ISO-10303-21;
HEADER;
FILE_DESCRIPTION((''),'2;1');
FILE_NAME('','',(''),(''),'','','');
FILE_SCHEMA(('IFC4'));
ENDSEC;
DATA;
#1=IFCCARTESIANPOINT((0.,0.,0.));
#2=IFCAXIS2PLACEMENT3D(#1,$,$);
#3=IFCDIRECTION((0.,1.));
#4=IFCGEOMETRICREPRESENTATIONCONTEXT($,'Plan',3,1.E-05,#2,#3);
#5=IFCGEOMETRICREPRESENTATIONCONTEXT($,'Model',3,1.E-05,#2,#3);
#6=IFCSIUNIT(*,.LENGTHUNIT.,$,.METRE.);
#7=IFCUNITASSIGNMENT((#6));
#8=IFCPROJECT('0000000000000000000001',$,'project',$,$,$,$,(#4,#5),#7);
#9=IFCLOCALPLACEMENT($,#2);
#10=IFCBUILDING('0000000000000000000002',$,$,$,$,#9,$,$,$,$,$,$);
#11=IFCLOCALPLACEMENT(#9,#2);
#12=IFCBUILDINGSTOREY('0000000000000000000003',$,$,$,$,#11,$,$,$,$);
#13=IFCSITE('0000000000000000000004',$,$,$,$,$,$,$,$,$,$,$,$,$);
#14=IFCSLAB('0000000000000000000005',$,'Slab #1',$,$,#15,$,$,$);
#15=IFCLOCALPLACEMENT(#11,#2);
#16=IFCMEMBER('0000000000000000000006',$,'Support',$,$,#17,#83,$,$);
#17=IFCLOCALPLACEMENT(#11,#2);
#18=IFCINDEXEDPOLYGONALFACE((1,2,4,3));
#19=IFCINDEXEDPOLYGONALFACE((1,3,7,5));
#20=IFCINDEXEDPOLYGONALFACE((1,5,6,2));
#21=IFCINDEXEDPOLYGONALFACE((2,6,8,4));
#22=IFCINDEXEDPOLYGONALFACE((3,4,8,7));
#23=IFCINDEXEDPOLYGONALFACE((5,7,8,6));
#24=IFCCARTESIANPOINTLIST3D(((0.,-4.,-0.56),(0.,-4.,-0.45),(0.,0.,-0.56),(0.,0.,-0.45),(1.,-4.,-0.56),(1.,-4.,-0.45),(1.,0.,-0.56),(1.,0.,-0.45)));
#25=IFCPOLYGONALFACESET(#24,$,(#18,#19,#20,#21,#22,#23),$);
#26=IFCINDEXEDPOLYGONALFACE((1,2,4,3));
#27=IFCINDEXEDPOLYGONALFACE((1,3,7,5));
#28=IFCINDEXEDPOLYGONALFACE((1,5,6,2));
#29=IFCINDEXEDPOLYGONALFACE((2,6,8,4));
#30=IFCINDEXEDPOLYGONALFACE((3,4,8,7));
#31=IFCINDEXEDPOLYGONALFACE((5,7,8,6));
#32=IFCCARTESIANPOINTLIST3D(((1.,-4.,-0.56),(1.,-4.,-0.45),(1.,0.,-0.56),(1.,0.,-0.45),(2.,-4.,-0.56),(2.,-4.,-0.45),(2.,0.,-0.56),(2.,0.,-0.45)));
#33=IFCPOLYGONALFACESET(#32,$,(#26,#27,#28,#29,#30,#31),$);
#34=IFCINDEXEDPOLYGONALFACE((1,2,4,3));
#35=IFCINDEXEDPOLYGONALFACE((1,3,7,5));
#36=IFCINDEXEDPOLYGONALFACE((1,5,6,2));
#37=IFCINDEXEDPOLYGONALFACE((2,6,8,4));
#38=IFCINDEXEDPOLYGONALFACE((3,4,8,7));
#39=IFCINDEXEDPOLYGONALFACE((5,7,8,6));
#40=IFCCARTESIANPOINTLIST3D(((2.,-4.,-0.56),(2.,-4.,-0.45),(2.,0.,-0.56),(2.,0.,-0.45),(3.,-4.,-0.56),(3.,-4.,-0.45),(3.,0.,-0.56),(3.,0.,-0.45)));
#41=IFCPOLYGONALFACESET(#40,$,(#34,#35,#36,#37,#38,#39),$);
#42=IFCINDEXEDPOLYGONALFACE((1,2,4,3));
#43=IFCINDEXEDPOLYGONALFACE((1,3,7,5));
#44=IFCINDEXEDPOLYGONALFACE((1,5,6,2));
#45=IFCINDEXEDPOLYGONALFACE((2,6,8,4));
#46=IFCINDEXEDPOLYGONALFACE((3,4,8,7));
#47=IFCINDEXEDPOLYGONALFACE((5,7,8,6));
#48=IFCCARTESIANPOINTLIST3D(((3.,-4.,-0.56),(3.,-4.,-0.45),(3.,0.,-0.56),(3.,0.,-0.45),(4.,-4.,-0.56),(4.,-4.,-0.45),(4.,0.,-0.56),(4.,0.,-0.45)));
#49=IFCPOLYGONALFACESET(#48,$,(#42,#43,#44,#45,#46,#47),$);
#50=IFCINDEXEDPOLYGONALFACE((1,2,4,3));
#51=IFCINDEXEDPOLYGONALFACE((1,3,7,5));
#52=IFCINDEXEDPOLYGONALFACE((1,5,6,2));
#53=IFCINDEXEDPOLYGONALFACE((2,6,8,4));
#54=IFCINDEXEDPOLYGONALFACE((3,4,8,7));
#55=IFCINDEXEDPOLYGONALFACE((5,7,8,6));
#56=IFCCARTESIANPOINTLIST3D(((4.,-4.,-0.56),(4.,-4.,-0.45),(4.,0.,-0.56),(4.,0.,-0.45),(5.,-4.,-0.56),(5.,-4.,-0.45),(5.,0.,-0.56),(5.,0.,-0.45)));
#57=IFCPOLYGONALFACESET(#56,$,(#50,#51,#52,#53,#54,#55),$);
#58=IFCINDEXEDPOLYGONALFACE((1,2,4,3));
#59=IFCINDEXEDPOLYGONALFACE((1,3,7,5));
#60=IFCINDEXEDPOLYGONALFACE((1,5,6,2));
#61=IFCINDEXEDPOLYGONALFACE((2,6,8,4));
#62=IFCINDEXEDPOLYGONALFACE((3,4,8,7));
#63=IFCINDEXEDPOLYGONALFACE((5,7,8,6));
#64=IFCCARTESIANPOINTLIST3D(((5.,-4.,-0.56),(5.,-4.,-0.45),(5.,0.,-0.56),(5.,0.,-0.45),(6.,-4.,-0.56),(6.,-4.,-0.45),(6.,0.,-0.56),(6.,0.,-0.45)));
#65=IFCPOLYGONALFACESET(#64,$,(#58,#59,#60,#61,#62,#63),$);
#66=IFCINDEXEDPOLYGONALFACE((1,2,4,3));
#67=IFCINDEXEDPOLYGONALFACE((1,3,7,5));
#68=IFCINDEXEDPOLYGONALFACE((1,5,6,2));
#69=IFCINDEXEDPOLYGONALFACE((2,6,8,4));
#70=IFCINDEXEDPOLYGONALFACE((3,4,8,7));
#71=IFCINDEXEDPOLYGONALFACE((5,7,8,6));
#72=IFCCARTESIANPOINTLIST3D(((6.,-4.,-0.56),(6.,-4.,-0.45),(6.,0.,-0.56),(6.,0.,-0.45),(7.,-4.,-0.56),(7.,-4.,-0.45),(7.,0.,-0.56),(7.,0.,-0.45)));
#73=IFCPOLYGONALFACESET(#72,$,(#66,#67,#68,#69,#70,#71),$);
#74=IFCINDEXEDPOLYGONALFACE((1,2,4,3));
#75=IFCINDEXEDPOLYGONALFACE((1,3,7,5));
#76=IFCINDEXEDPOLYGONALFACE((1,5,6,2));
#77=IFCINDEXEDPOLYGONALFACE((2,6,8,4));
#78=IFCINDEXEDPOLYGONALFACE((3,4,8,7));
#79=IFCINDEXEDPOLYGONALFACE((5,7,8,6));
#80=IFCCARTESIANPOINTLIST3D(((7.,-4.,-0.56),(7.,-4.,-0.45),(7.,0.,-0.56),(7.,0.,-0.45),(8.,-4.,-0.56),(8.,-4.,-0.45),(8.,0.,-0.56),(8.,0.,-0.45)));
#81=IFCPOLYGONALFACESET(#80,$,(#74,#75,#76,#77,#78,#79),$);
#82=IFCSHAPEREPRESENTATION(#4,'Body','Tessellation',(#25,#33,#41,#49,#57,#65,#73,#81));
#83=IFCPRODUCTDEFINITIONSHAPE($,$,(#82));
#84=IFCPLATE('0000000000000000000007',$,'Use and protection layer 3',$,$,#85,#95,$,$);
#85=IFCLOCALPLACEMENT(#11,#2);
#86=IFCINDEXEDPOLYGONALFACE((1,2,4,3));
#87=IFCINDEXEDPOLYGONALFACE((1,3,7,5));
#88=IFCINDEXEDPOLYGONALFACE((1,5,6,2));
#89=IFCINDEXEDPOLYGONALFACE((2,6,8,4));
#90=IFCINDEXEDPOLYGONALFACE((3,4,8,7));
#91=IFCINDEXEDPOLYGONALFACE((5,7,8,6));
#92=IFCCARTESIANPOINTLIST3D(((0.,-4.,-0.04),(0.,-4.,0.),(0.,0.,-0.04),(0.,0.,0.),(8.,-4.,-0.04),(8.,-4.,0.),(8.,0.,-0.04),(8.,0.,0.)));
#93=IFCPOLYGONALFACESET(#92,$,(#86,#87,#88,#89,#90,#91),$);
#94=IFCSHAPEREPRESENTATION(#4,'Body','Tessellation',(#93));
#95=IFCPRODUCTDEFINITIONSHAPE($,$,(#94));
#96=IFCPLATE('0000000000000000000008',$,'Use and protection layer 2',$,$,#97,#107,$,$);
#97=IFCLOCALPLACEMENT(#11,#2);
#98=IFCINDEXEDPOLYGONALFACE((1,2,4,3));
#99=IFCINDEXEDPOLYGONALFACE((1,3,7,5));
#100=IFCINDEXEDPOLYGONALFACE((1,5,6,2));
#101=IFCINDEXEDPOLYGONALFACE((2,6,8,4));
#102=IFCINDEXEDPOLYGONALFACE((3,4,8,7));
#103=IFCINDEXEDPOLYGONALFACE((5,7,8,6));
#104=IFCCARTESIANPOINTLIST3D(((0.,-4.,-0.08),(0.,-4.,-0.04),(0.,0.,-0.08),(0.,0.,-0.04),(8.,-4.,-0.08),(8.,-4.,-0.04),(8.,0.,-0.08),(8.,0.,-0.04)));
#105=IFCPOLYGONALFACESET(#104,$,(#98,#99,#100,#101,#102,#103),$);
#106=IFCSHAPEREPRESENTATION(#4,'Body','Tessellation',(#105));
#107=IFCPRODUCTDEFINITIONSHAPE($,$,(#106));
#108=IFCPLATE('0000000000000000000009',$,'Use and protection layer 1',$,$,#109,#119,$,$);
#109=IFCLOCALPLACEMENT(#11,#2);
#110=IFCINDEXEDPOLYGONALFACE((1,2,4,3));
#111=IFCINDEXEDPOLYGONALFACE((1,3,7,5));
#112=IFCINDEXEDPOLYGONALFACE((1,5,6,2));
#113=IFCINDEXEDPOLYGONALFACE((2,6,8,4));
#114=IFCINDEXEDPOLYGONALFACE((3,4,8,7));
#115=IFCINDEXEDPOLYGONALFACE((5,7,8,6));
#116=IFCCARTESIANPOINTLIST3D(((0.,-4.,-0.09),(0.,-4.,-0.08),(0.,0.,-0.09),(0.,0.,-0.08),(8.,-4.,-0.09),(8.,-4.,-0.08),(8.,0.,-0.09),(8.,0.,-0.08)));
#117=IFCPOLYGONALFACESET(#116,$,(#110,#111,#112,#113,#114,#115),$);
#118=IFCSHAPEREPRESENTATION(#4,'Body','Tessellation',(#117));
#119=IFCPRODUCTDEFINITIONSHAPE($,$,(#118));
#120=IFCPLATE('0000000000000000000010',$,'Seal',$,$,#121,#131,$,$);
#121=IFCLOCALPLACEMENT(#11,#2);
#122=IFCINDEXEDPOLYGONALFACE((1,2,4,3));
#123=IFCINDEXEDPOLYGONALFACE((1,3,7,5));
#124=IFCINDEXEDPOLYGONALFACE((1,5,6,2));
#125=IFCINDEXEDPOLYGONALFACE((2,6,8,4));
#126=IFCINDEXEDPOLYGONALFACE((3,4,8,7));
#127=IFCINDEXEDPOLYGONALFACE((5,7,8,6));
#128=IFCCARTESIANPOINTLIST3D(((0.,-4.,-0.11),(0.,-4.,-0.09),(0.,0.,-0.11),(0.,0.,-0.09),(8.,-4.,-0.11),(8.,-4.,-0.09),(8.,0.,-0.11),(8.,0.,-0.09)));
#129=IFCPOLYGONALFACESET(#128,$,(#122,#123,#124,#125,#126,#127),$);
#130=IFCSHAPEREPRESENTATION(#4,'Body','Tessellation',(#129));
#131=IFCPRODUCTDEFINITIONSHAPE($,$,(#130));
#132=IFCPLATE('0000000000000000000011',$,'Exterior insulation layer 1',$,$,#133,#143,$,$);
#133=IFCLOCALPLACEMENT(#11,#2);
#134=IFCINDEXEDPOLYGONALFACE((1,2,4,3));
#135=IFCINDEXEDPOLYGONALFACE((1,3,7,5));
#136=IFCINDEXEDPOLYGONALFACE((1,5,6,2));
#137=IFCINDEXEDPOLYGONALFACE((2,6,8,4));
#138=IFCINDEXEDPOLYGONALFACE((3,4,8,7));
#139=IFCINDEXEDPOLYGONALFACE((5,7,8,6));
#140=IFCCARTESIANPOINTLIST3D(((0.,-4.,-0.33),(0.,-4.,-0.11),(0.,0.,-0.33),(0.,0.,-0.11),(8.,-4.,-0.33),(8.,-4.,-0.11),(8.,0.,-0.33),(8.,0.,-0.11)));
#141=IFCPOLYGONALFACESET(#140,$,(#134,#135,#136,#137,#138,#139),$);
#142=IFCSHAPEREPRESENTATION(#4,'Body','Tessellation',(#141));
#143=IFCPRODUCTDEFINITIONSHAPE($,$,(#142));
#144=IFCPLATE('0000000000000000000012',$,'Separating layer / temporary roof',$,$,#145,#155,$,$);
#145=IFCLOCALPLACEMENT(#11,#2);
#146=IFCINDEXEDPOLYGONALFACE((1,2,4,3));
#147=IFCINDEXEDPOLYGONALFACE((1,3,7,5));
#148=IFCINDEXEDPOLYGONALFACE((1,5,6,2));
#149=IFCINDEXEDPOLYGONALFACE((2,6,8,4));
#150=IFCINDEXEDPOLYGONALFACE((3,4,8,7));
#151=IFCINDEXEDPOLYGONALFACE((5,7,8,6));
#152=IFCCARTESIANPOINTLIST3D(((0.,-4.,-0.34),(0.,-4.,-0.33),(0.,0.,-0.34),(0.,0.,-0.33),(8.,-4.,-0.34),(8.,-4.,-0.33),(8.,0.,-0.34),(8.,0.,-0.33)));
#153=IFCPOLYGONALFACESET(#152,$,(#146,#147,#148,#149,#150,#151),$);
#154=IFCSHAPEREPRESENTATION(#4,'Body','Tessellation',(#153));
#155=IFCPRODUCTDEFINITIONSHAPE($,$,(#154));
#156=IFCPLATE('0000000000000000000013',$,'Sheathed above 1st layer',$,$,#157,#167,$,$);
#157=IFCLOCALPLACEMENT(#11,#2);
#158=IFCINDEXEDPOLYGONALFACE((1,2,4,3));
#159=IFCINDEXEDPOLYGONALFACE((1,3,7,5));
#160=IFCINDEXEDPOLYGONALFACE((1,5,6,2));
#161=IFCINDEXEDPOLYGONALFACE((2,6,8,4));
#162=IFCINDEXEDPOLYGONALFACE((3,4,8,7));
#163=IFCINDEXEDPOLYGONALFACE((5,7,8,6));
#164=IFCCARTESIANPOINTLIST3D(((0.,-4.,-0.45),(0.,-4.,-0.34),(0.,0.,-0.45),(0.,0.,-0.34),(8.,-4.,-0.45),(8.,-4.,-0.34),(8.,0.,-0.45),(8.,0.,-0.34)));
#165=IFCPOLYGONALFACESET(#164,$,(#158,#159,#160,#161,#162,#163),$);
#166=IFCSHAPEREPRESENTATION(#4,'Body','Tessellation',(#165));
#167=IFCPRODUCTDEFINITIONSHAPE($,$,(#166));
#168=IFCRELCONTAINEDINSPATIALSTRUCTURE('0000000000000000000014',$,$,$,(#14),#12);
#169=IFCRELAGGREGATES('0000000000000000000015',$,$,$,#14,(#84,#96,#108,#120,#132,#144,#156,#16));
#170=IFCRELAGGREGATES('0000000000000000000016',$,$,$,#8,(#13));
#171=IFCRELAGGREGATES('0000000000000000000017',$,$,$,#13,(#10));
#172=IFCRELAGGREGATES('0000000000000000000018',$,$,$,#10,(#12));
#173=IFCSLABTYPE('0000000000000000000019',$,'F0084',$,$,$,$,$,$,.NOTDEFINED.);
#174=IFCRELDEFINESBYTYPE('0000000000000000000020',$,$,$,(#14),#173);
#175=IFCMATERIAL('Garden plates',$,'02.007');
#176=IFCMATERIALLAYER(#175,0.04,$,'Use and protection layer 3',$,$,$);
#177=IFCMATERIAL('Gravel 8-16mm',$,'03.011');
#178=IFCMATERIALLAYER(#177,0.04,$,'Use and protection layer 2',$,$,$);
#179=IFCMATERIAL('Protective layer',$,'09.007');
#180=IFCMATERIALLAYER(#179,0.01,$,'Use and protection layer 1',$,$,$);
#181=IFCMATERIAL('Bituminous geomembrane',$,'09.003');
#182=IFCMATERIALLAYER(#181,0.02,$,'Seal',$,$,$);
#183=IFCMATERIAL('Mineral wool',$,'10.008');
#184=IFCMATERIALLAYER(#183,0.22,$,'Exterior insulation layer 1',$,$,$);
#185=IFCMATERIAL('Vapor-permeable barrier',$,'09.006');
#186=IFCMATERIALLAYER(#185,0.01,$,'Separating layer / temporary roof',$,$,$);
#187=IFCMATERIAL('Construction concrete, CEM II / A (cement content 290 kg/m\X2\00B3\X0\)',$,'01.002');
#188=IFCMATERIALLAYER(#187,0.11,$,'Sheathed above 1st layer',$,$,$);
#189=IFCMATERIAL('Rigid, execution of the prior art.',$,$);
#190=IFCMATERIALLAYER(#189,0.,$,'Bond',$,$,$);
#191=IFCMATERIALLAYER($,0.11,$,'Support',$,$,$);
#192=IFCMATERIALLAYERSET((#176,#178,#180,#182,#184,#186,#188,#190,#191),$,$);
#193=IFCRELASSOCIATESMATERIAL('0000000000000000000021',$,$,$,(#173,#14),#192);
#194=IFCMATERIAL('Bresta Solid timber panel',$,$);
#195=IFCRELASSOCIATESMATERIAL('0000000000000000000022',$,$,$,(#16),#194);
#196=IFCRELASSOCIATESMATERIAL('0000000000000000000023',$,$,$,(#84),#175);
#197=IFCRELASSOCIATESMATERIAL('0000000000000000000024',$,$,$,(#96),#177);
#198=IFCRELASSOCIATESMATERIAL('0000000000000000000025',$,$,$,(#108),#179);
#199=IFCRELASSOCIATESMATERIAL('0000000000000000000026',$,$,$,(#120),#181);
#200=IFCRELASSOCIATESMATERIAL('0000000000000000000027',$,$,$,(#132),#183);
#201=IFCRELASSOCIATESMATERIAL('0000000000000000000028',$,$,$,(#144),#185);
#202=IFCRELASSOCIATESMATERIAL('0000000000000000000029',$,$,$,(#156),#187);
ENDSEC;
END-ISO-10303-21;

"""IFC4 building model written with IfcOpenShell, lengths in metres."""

from ifc_helpers import new_model, si_unit, direction, frame, frame_2d, origin, origin_with_axes, place, context, project, spatial, rectangle, extrude, material, layer, layer_set, type_object, element, aggregate, save


model = new_model("IFC4")

# Units and contexts
plan_context = context("Plan", 3, precision=1e-05, world=origin(), true_north=direction((0.0, 1.0)))
model_context = context("Model", 3, precision=1e-05, world=origin(), true_north=direction((0.0, 1.0)))
ifc_project = project(units=[si_unit("LENGTHUNIT", "METRE")], contexts=[plan_context, model_context])

# Site, building, storey
site = spatial("IfcSite", under=ifc_project)
building_placement = place(None, origin())
building = spatial("IfcBuilding", under=site, at=building_placement)
storey_placement = place(building_placement, origin())
storey = spatial("IfcBuildingStorey", under=building, at=storey_placement)

# Slab, member, plates
ifc_material_1 = material(Name="Garden plates", Category="02.007")
ifc_layer_1 = layer(ifc_material_1, 0.04, Name="Use and protection layer 3")
ifc_material_2 = material(Name="Gravel 8-16mm", Category="03.011")
ifc_layer_2 = layer(ifc_material_2, 0.04, Name="Use and protection layer 2")
ifc_material_3 = material(Name="Protective layer", Category="09.007")
ifc_layer_3 = layer(ifc_material_3, 0.01, Name="Use and protection layer 1")
ifc_material_4 = material(Name="Bituminous geomembrane", Category="09.003")
ifc_layer_4 = layer(ifc_material_4, 0.02, Name="Seal")
ifc_material_5 = material(Name="Mineral wool", Category="10.008")
ifc_layer_5 = layer(ifc_material_5, 0.22, Name="Exterior insulation layer 1")
ifc_material_6 = material(Name="Vapor-permeable barrier", Category="09.006")
ifc_layer_6 = layer(ifc_material_6, 0.01, Name="Separating layer / temporary roof")
ifc_material_7 = material(Name="Construction concrete, CEM II / A (cement content 290 kg/m³)", Category="01.002")
ifc_layer_7 = layer(ifc_material_7, 0.11, Name="Sheathed above 1st layer")
ifc_material_8 = material(Name="Rigid, execution of the prior art.")
ifc_layer_8 = layer(ifc_material_8, 0.0, Name="Bond")
ifc_layer_9 = layer(None, 0.11, Name="Support")
ifc_layer_set = layer_set([ifc_layer_1, ifc_layer_2, ifc_layer_3, ifc_layer_4, ifc_layer_5, ifc_layer_6, ifc_layer_7, ifc_layer_8, ifc_layer_9])
slab_type = type_object("IfcSlabType", Name="F0084", PredefinedType="NOTDEFINED", material=ifc_layer_set)
slab_placement = place(None, frame((0.0, 0.0, 0.0), z_axis=(0.0, 0.0, -1.0), x_axis=(1.0, 0.0, 0.0)))
slab = element("IfcSlab", 1, at=slab_placement, inside=storey, type_object=slab_type, material=ifc_layer_set, Name="Slab #1")
ifc_material_9 = material(Name="Bresta Solid timber panel")
member_placement = place(slab_placement, origin())
member = element("IfcMember", 2, at=member_placement, material=ifc_material_9, Name="Support", context=plan_context, shape_type="SweptSolid", body=[
    extrude(rectangle(XDim=1.0, YDim=0.11, at=frame_2d((0.5, 0.055), x_axis=(1.0, 0.0))), frame((0.0, 4.0, 0.45), z_axis=(0.0, -1.0, 0.0), x_axis=(1.0, 0.0, 0.0)), (0.0, 0.0, 1.0), 4.0),
    extrude(rectangle(XDim=1.0, YDim=0.11, at=frame_2d((0.5, 0.055), x_axis=(1.0, 0.0))), frame((1.0, 4.0, 0.45), z_axis=(0.0, -1.0, 0.0), x_axis=(1.0, 0.0, 0.0)), (0.0, 0.0, 1.0), 4.0),
    extrude(rectangle(XDim=1.0, YDim=0.11, at=frame_2d((0.5, 0.055), x_axis=(1.0, 0.0))), frame((2.0, 4.0, 0.45), z_axis=(0.0, -1.0, 0.0), x_axis=(1.0, 0.0, 0.0)), (0.0, 0.0, 1.0), 4.0),
    extrude(rectangle(XDim=1.0, YDim=0.11, at=frame_2d((0.5, 0.055), x_axis=(1.0, 0.0))), frame((3.0, 4.0, 0.45), z_axis=(0.0, -1.0, 0.0), x_axis=(1.0, 0.0, 0.0)), (0.0, 0.0, 1.0), 4.0),
    extrude(rectangle(XDim=1.0, YDim=0.11, at=frame_2d((0.5, 0.055), x_axis=(1.0, 0.0))), frame((4.0, 4.0, 0.45), z_axis=(0.0, -1.0, 0.0), x_axis=(1.0, 0.0, 0.0)), (0.0, 0.0, 1.0), 4.0),
    extrude(rectangle(XDim=1.0, YDim=0.11, at=frame_2d((0.5, 0.055), x_axis=(1.0, 0.0))), frame((5.0, 4.0, 0.45), z_axis=(0.0, -1.0, 0.0), x_axis=(1.0, 0.0, 0.0)), (0.0, 0.0, 1.0), 4.0),
    extrude(rectangle(XDim=1.0, YDim=0.11, at=frame_2d((0.5, 0.055), x_axis=(1.0, 0.0))), frame((6.0, 4.0, 0.45), z_axis=(0.0, -1.0, 0.0), x_axis=(1.0, 0.0, 0.0)), (0.0, 0.0, 1.0), 4.0),
    extrude(rectangle(XDim=1.0, YDim=0.11, at=frame_2d((0.5, 0.055), x_axis=(1.0, 0.0))), frame((7.0, 4.0, 0.45), z_axis=(0.0, -1.0, 0.0), x_axis=(1.0, 0.0, 0.0)), (0.0, 0.0, 1.0), 4.0),
])
plate_1_placement = place(slab_placement, origin())
plate_1 = element("IfcPlate", 3, at=plate_1_placement, material=ifc_material_1, Name="Use and protection layer 3", context=plan_context, shape_type="SweptSolid", body=[
    extrude(rectangle(XDim=8.0, YDim=4.0, at=frame_2d((4.0, 2.0), x_axis=(1.0, 0.0))), origin_with_axes(), (0.0, 0.0, 1.0), 0.04),
])
plate_2_placement = place(slab_placement, origin())
plate_2 = element("IfcPlate", 4, at=plate_2_placement, material=ifc_material_2, Name="Use and protection layer 2", context=plan_context, shape_type="SweptSolid", body=[
    extrude(rectangle(XDim=8.0, YDim=4.0, at=frame_2d((4.0, 2.0), x_axis=(1.0, 0.0))), frame((0.0, 0.0, 0.04), z_axis=(0.0, 0.0, 1.0), x_axis=(1.0, 0.0, 0.0)), (0.0, 0.0, 1.0), 0.04),
])
plate_3_placement = place(slab_placement, origin())
plate_3 = element("IfcPlate", 5, at=plate_3_placement, material=ifc_material_3, Name="Use and protection layer 1", context=plan_context, shape_type="SweptSolid", body=[
    extrude(rectangle(XDim=8.0, YDim=4.0, at=frame_2d((4.0, 2.0), x_axis=(1.0, 0.0))), frame((0.0, 0.0, 0.08), z_axis=(0.0, 0.0, 1.0), x_axis=(1.0, 0.0, 0.0)), (0.0, 0.0, 1.0), 0.01),
])
plate_4_placement = place(slab_placement, origin())
plate_4 = element("IfcPlate", 6, at=plate_4_placement, material=ifc_material_4, Name="Seal", context=plan_context, shape_type="SweptSolid", body=[
    extrude(rectangle(XDim=8.0, YDim=4.0, at=frame_2d((4.0, 2.0), x_axis=(1.0, 0.0))), frame((0.0, 0.0, 0.09), z_axis=(0.0, 0.0, 1.0), x_axis=(1.0, 0.0, 0.0)), (0.0, 0.0, 1.0), 0.02),
])
plate_5_placement = place(slab_placement, origin())
plate_5 = element("IfcPlate", 7, at=plate_5_placement, material=ifc_material_5, Name="Exterior insulation layer 1", context=plan_context, shape_type="SweptSolid", body=[
    extrude(rectangle(XDim=8.0, YDim=4.0, at=frame_2d((4.0, 2.0), x_axis=(1.0, 0.0))), frame((0.0, 0.0, 0.11), z_axis=(0.0, 0.0, 1.0), x_axis=(1.0, 0.0, 0.0)), (0.0, 0.0, 1.0), 0.22),
])
plate_6_placement = place(slab_placement, origin())
plate_6 = element("IfcPlate", 8, at=plate_6_placement, material=ifc_material_6, Name="Separating layer / temporary roof", context=plan_context, shape_type="SweptSolid", body=[
    extrude(rectangle(XDim=8.0, YDim=4.0, at=frame_2d((4.0, 2.0), x_axis=(1.0, 0.0))), frame((0.0, 0.0, 0.33), z_axis=(0.0, 0.0, 1.0), x_axis=(1.0, 0.0, 0.0)), (0.0, 0.0, 1.0), 0.01),
])
plate_7_placement = place(slab_placement, origin())
plate_7 = element("IfcPlate", 9, at=plate_7_placement, material=ifc_material_7, Name="Sheathed above 1st layer", context=plan_context, shape_type="SweptSolid", body=[
    extrude(rectangle(XDim=8.0, YDim=4.0, at=frame_2d((4.0, 2.0), x_axis=(1.0, 0.0))), frame((0.0, 0.0, 0.34), z_axis=(0.0, 0.0, 1.0), x_axis=(1.0, 0.0, 0.0)), (0.0, 0.0, 1.0), 0.11),
])
aggregate(slab, [plate_1, plate_2, plate_3, plate_4, plate_5, plate_6, plate_7, member])

save(model, "model.ifc")
